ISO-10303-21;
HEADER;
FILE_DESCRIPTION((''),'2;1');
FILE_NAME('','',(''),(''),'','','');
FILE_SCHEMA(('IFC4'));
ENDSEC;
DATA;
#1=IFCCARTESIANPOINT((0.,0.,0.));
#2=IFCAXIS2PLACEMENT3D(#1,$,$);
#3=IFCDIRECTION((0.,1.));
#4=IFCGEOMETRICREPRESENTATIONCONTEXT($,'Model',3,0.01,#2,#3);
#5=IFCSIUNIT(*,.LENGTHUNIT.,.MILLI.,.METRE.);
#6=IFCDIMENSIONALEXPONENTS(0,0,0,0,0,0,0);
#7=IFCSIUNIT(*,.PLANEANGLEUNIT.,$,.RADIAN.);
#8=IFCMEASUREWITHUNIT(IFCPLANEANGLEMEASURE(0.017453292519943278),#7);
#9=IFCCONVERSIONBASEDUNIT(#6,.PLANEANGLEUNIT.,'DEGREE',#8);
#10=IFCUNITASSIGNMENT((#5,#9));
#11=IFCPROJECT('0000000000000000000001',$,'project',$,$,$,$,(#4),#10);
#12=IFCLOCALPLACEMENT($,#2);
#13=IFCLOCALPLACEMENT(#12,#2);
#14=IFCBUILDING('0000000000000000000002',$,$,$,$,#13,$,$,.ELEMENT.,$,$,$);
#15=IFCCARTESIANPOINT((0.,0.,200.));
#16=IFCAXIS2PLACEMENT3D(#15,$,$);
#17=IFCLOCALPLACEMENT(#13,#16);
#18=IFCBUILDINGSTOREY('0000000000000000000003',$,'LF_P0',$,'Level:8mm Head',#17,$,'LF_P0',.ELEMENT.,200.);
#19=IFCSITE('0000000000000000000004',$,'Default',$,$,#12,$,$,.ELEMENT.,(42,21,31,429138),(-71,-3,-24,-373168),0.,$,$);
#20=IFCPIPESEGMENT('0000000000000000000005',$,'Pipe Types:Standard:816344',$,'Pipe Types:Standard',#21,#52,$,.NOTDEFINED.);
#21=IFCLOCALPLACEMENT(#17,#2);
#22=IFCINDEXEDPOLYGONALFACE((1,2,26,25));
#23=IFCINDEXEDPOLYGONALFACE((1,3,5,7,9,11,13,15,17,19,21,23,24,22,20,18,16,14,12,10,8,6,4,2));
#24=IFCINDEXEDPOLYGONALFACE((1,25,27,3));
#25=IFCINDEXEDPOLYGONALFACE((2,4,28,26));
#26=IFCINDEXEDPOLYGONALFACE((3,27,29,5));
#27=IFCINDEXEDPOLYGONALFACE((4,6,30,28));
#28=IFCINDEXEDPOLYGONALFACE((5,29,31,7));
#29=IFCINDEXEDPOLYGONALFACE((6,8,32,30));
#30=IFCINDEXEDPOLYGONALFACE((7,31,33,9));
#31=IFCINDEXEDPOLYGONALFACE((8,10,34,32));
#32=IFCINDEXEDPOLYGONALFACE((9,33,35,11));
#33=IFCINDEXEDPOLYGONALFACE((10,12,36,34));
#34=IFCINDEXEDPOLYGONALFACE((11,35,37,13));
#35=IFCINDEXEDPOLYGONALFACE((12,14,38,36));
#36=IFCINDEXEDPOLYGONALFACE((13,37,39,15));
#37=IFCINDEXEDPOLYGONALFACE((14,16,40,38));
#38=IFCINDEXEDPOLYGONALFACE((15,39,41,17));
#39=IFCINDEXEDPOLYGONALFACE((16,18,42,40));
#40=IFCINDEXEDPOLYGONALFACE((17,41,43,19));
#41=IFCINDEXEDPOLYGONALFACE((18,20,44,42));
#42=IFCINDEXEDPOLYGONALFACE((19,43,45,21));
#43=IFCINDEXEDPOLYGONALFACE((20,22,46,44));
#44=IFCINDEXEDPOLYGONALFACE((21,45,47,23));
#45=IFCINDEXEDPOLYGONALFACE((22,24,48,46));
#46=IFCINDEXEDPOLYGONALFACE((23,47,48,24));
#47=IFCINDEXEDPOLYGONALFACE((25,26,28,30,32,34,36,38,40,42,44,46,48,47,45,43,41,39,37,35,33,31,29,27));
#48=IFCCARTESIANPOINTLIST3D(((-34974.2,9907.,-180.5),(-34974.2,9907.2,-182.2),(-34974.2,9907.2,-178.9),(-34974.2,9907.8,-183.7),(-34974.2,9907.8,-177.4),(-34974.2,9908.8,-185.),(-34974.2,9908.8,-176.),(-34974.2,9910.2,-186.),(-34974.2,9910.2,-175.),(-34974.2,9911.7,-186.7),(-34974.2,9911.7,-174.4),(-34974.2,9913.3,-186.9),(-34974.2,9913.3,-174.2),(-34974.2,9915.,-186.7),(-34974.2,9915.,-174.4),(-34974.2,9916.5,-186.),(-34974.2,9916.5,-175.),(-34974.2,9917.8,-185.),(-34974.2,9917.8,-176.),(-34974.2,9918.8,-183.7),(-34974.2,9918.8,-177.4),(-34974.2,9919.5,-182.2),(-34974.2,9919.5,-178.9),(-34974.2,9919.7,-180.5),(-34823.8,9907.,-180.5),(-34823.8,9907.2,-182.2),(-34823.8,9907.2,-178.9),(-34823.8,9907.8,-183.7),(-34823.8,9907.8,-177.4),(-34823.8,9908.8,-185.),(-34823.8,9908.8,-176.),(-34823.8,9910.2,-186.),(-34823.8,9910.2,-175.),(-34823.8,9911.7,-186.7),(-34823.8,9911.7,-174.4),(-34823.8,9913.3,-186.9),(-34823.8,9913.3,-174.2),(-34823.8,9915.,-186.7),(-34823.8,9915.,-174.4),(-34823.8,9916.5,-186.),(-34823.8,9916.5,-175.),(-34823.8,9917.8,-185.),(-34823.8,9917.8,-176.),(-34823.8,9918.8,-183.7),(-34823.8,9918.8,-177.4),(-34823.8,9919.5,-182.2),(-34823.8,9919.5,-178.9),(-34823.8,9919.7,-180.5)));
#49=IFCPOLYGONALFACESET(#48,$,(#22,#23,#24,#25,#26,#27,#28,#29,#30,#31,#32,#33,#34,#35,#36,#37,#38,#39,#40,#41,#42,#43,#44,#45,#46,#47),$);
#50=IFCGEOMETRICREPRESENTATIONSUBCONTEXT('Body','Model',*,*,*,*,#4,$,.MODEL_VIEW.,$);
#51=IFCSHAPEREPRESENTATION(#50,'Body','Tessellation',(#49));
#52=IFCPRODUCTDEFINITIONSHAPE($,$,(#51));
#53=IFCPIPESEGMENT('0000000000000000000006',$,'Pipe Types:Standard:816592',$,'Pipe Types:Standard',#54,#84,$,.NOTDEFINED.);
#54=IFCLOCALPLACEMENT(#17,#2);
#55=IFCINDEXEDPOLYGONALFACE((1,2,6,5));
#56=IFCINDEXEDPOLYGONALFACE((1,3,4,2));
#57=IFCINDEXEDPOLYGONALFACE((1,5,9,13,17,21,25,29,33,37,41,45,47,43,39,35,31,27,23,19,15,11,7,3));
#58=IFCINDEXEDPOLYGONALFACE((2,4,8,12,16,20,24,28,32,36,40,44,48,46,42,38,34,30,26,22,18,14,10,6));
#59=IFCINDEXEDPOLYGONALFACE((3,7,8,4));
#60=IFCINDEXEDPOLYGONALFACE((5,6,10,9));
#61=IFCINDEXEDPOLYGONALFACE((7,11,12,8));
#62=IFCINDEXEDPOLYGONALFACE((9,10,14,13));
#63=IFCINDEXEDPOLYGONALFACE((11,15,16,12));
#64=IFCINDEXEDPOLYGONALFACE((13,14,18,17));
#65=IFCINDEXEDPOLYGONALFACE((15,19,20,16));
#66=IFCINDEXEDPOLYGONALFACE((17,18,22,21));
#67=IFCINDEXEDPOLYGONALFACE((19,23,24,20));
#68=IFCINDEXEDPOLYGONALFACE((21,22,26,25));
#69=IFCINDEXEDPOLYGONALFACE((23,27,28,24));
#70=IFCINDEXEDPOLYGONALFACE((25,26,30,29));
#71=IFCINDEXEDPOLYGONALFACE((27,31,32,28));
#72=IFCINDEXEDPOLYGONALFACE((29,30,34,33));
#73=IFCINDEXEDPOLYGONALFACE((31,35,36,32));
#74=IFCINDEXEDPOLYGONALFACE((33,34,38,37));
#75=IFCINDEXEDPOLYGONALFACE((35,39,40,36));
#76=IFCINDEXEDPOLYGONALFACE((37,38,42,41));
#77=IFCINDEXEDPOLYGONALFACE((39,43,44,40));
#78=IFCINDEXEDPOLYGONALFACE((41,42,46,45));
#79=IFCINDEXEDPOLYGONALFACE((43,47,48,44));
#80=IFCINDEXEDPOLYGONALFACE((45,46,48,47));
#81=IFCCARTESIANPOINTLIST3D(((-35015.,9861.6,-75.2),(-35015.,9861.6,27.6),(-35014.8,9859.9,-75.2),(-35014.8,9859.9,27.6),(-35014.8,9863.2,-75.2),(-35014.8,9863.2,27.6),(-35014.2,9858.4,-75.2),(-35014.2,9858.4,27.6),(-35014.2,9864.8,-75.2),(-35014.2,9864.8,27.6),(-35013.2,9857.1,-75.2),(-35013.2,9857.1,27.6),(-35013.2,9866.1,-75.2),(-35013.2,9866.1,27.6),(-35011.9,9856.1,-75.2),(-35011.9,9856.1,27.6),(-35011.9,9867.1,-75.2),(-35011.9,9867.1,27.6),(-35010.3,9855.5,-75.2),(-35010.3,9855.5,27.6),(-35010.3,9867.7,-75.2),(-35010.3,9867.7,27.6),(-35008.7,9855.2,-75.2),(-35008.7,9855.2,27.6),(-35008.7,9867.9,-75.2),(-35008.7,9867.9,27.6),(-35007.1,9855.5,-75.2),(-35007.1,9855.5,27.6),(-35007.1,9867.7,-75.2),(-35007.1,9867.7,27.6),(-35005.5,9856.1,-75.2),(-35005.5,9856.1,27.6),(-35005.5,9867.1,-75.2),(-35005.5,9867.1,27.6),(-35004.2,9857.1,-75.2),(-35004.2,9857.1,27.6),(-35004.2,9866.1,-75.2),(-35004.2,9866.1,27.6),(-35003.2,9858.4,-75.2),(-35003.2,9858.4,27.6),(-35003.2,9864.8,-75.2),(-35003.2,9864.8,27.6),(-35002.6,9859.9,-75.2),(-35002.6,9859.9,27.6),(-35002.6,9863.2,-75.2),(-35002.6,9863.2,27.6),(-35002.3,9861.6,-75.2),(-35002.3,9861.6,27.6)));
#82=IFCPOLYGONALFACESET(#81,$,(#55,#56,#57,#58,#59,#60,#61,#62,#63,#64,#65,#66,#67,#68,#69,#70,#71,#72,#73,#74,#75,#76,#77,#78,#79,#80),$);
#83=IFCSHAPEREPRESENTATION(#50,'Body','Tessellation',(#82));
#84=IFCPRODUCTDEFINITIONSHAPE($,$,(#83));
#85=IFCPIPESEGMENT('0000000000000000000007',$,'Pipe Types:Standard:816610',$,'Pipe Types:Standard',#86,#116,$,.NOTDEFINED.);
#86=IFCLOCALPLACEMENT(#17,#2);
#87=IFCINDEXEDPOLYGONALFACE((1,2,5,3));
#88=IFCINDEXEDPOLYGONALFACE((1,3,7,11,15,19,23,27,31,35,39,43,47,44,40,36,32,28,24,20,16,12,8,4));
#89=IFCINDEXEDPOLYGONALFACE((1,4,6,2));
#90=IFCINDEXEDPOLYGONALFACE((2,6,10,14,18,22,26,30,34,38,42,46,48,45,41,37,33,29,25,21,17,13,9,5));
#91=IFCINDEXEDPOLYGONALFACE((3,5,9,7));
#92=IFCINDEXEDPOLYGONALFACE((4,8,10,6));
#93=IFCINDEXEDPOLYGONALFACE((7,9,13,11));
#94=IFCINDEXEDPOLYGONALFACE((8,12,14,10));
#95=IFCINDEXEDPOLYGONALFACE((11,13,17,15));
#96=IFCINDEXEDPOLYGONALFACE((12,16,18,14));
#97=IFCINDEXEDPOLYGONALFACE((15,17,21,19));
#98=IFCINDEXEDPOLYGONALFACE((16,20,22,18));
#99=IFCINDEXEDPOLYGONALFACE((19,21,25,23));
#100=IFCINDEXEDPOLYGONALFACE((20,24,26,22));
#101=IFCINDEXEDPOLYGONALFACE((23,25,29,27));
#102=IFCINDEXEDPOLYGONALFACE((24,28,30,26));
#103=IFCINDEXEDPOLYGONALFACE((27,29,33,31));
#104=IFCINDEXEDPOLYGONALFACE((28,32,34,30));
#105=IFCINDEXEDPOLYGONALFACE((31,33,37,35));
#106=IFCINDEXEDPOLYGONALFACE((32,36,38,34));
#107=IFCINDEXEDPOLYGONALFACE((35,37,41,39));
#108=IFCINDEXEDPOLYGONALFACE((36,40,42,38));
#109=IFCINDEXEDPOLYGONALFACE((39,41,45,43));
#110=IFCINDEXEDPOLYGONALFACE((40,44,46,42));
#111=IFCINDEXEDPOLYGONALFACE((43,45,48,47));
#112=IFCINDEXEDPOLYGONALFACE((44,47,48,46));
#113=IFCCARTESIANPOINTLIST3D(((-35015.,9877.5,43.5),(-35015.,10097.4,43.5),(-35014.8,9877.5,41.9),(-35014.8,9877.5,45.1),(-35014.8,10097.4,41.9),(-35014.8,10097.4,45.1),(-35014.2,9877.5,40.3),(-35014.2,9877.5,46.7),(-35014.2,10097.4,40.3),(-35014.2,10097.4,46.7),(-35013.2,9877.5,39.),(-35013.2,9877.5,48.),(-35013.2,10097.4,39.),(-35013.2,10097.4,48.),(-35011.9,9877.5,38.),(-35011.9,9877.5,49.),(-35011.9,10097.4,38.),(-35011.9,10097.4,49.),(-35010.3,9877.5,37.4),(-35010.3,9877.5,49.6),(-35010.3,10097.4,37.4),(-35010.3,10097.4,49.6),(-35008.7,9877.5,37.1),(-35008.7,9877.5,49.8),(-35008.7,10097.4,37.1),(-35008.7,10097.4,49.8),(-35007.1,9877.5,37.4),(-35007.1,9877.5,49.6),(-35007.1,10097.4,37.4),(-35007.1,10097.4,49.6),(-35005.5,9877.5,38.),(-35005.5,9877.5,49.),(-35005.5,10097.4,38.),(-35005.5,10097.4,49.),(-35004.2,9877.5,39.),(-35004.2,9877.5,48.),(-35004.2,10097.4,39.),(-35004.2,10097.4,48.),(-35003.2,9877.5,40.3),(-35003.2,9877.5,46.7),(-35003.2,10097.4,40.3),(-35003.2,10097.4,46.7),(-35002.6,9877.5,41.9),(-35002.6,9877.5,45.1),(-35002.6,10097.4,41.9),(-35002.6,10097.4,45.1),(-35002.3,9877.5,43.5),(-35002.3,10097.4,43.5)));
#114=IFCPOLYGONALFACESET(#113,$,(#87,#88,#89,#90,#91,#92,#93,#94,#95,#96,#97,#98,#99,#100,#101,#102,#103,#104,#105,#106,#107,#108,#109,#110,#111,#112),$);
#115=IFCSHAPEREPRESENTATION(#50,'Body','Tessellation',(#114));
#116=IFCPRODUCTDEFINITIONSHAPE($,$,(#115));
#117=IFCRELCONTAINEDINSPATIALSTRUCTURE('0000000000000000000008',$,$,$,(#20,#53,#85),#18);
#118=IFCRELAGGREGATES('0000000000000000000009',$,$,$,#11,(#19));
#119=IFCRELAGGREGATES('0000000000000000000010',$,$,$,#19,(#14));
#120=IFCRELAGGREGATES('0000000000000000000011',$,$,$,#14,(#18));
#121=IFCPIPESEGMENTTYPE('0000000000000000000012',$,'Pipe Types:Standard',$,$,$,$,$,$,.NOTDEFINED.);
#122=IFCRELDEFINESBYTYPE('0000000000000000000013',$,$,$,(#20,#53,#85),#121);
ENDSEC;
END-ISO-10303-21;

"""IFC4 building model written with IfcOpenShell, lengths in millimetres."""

from ifc_helpers import new_model, entity, si_unit, converted_unit, direction, frame, origin, place, context, subcontext, project, spatial, arc, indexed_curve, outline, extrude, type_object, element, save


model = new_model("IFC4")

# Units and contexts
model_context = context("Model", 3, precision=0.01, world=origin(), true_north=direction((0.0, 1.0)))
body_context = subcontext(model_context, "Body", "Model", "MODEL_VIEW")
ifc_project = project(units=[si_unit("LENGTHUNIT", "METRE", prefix="MILLI"), converted_unit("PLANEANGLEUNIT", "DEGREE", entity("IfcPlaneAngleMeasure", 0.017453292519943278), si_unit("PLANEANGLEUNIT", "RADIAN"), dimensions=[0, 0, 0, 0, 0, 0, 0])], contexts=[model_context])

# Site, building, storey
site_placement = place(None, origin())
site = spatial("IfcSite", under=ifc_project, at=site_placement, Name="Default", CompositionType="ELEMENT", RefLatitude=(42, 21, 31, 429138), RefLongitude=(-71, -3, -24, -373168), RefElevation=0.0)
building_placement = place(site_placement, origin())
building = spatial("IfcBuilding", under=site, at=building_placement, CompositionType="ELEMENT")
storey_placement = place(building_placement, frame((0.0, 0.0, 200.0)))
storey = spatial("IfcBuildingStorey", under=building, at=storey_placement, Name="LF_P0", ObjectType="Level:8mm Head", LongName="LF_P0", CompositionType="ELEMENT", Elevation=200.0)

# Pipe segments
pipe_segment_type = type_object("IfcPipeSegmentType", Name="Pipe Types:Standard", PredefinedType="NOTDEFINED")
pipe_segment_1_placement = place(storey_placement, origin())
element("IfcPipeSegment", 1, at=pipe_segment_1_placement, inside=storey, type_object=pipe_segment_type, Name="Pipe Types:Standard:816344", ObjectType="Pipe Types:Standard", PredefinedType="NOTDEFINED", context=body_context, shape_type="SweptSolid", body=[
    extrude(outline(indexed_curve([(6.4, 0.0), (4.5, 4.5), (0.0, 6.3), (-4.5, 4.5), (-6.4, 0.0), (-4.5, -4.5), (0.0, -6.4), (4.5, -4.5)], segments=[arc(1, 2, 3), arc(3, 4, 5), arc(5, 6, 7), arc(7, 8, 1)], self_intersect=False)), frame((-34974.2, 9913.3, -180.5), z_axis=(1.0, 0.0, 0.0), x_axis=(0.0, -1.0, 0.0)), (0.0, 0.0, 1.0), 150.4),
])
pipe_segment_2_placement = place(storey_placement, origin())
element("IfcPipeSegment", 2, at=pipe_segment_2_placement, inside=storey, type_object=pipe_segment_type, Name="Pipe Types:Standard:816592", ObjectType="Pipe Types:Standard", PredefinedType="NOTDEFINED", context=body_context, shape_type="SweptSolid", body=[
    extrude(outline(indexed_curve([(6.3, 0.0), (4.5, 4.5), (0.0, 6.4), (-4.5, 4.5), (-6.3, 0.0), (-4.5, -4.5), (0.0, -6.3), (4.5, -4.5)], segments=[arc(1, 2, 3), arc(3, 4, 5), arc(5, 6, 7), arc(7, 8, 1)], self_intersect=False)), frame((-35008.7, 9861.6, -75.2), z_axis=(0.0, 0.0, 1.0), x_axis=(-1.0, 0.0, 0.0)), (0.0, 0.0, 1.0), 102.8),
])
pipe_segment_3_placement = place(storey_placement, origin())
element("IfcPipeSegment", 3, at=pipe_segment_3_placement, inside=storey, type_object=pipe_segment_type, Name="Pipe Types:Standard:816610", ObjectType="Pipe Types:Standard", PredefinedType="NOTDEFINED", context=body_context, shape_type="SweptSolid", body=[
    extrude(outline(indexed_curve([(6.3, 0.0), (4.5, 4.5), (0.0, 6.4), (-4.5, 4.5), (-6.3, 0.0), (-4.5, -4.5), (0.0, -6.4), (4.5, -4.5)], segments=[arc(1, 2, 3), arc(3, 4, 5), arc(5, 6, 7), arc(7, 8, 1)], self_intersect=False)), frame((-35008.7, 9877.5, 43.5), z_axis=(0.0, 1.0, 0.0), x_axis=(1.0, 0.0, 0.0)), (0.0, 0.0, 1.0), 219.9),
])

save(model, "model.ifc")
